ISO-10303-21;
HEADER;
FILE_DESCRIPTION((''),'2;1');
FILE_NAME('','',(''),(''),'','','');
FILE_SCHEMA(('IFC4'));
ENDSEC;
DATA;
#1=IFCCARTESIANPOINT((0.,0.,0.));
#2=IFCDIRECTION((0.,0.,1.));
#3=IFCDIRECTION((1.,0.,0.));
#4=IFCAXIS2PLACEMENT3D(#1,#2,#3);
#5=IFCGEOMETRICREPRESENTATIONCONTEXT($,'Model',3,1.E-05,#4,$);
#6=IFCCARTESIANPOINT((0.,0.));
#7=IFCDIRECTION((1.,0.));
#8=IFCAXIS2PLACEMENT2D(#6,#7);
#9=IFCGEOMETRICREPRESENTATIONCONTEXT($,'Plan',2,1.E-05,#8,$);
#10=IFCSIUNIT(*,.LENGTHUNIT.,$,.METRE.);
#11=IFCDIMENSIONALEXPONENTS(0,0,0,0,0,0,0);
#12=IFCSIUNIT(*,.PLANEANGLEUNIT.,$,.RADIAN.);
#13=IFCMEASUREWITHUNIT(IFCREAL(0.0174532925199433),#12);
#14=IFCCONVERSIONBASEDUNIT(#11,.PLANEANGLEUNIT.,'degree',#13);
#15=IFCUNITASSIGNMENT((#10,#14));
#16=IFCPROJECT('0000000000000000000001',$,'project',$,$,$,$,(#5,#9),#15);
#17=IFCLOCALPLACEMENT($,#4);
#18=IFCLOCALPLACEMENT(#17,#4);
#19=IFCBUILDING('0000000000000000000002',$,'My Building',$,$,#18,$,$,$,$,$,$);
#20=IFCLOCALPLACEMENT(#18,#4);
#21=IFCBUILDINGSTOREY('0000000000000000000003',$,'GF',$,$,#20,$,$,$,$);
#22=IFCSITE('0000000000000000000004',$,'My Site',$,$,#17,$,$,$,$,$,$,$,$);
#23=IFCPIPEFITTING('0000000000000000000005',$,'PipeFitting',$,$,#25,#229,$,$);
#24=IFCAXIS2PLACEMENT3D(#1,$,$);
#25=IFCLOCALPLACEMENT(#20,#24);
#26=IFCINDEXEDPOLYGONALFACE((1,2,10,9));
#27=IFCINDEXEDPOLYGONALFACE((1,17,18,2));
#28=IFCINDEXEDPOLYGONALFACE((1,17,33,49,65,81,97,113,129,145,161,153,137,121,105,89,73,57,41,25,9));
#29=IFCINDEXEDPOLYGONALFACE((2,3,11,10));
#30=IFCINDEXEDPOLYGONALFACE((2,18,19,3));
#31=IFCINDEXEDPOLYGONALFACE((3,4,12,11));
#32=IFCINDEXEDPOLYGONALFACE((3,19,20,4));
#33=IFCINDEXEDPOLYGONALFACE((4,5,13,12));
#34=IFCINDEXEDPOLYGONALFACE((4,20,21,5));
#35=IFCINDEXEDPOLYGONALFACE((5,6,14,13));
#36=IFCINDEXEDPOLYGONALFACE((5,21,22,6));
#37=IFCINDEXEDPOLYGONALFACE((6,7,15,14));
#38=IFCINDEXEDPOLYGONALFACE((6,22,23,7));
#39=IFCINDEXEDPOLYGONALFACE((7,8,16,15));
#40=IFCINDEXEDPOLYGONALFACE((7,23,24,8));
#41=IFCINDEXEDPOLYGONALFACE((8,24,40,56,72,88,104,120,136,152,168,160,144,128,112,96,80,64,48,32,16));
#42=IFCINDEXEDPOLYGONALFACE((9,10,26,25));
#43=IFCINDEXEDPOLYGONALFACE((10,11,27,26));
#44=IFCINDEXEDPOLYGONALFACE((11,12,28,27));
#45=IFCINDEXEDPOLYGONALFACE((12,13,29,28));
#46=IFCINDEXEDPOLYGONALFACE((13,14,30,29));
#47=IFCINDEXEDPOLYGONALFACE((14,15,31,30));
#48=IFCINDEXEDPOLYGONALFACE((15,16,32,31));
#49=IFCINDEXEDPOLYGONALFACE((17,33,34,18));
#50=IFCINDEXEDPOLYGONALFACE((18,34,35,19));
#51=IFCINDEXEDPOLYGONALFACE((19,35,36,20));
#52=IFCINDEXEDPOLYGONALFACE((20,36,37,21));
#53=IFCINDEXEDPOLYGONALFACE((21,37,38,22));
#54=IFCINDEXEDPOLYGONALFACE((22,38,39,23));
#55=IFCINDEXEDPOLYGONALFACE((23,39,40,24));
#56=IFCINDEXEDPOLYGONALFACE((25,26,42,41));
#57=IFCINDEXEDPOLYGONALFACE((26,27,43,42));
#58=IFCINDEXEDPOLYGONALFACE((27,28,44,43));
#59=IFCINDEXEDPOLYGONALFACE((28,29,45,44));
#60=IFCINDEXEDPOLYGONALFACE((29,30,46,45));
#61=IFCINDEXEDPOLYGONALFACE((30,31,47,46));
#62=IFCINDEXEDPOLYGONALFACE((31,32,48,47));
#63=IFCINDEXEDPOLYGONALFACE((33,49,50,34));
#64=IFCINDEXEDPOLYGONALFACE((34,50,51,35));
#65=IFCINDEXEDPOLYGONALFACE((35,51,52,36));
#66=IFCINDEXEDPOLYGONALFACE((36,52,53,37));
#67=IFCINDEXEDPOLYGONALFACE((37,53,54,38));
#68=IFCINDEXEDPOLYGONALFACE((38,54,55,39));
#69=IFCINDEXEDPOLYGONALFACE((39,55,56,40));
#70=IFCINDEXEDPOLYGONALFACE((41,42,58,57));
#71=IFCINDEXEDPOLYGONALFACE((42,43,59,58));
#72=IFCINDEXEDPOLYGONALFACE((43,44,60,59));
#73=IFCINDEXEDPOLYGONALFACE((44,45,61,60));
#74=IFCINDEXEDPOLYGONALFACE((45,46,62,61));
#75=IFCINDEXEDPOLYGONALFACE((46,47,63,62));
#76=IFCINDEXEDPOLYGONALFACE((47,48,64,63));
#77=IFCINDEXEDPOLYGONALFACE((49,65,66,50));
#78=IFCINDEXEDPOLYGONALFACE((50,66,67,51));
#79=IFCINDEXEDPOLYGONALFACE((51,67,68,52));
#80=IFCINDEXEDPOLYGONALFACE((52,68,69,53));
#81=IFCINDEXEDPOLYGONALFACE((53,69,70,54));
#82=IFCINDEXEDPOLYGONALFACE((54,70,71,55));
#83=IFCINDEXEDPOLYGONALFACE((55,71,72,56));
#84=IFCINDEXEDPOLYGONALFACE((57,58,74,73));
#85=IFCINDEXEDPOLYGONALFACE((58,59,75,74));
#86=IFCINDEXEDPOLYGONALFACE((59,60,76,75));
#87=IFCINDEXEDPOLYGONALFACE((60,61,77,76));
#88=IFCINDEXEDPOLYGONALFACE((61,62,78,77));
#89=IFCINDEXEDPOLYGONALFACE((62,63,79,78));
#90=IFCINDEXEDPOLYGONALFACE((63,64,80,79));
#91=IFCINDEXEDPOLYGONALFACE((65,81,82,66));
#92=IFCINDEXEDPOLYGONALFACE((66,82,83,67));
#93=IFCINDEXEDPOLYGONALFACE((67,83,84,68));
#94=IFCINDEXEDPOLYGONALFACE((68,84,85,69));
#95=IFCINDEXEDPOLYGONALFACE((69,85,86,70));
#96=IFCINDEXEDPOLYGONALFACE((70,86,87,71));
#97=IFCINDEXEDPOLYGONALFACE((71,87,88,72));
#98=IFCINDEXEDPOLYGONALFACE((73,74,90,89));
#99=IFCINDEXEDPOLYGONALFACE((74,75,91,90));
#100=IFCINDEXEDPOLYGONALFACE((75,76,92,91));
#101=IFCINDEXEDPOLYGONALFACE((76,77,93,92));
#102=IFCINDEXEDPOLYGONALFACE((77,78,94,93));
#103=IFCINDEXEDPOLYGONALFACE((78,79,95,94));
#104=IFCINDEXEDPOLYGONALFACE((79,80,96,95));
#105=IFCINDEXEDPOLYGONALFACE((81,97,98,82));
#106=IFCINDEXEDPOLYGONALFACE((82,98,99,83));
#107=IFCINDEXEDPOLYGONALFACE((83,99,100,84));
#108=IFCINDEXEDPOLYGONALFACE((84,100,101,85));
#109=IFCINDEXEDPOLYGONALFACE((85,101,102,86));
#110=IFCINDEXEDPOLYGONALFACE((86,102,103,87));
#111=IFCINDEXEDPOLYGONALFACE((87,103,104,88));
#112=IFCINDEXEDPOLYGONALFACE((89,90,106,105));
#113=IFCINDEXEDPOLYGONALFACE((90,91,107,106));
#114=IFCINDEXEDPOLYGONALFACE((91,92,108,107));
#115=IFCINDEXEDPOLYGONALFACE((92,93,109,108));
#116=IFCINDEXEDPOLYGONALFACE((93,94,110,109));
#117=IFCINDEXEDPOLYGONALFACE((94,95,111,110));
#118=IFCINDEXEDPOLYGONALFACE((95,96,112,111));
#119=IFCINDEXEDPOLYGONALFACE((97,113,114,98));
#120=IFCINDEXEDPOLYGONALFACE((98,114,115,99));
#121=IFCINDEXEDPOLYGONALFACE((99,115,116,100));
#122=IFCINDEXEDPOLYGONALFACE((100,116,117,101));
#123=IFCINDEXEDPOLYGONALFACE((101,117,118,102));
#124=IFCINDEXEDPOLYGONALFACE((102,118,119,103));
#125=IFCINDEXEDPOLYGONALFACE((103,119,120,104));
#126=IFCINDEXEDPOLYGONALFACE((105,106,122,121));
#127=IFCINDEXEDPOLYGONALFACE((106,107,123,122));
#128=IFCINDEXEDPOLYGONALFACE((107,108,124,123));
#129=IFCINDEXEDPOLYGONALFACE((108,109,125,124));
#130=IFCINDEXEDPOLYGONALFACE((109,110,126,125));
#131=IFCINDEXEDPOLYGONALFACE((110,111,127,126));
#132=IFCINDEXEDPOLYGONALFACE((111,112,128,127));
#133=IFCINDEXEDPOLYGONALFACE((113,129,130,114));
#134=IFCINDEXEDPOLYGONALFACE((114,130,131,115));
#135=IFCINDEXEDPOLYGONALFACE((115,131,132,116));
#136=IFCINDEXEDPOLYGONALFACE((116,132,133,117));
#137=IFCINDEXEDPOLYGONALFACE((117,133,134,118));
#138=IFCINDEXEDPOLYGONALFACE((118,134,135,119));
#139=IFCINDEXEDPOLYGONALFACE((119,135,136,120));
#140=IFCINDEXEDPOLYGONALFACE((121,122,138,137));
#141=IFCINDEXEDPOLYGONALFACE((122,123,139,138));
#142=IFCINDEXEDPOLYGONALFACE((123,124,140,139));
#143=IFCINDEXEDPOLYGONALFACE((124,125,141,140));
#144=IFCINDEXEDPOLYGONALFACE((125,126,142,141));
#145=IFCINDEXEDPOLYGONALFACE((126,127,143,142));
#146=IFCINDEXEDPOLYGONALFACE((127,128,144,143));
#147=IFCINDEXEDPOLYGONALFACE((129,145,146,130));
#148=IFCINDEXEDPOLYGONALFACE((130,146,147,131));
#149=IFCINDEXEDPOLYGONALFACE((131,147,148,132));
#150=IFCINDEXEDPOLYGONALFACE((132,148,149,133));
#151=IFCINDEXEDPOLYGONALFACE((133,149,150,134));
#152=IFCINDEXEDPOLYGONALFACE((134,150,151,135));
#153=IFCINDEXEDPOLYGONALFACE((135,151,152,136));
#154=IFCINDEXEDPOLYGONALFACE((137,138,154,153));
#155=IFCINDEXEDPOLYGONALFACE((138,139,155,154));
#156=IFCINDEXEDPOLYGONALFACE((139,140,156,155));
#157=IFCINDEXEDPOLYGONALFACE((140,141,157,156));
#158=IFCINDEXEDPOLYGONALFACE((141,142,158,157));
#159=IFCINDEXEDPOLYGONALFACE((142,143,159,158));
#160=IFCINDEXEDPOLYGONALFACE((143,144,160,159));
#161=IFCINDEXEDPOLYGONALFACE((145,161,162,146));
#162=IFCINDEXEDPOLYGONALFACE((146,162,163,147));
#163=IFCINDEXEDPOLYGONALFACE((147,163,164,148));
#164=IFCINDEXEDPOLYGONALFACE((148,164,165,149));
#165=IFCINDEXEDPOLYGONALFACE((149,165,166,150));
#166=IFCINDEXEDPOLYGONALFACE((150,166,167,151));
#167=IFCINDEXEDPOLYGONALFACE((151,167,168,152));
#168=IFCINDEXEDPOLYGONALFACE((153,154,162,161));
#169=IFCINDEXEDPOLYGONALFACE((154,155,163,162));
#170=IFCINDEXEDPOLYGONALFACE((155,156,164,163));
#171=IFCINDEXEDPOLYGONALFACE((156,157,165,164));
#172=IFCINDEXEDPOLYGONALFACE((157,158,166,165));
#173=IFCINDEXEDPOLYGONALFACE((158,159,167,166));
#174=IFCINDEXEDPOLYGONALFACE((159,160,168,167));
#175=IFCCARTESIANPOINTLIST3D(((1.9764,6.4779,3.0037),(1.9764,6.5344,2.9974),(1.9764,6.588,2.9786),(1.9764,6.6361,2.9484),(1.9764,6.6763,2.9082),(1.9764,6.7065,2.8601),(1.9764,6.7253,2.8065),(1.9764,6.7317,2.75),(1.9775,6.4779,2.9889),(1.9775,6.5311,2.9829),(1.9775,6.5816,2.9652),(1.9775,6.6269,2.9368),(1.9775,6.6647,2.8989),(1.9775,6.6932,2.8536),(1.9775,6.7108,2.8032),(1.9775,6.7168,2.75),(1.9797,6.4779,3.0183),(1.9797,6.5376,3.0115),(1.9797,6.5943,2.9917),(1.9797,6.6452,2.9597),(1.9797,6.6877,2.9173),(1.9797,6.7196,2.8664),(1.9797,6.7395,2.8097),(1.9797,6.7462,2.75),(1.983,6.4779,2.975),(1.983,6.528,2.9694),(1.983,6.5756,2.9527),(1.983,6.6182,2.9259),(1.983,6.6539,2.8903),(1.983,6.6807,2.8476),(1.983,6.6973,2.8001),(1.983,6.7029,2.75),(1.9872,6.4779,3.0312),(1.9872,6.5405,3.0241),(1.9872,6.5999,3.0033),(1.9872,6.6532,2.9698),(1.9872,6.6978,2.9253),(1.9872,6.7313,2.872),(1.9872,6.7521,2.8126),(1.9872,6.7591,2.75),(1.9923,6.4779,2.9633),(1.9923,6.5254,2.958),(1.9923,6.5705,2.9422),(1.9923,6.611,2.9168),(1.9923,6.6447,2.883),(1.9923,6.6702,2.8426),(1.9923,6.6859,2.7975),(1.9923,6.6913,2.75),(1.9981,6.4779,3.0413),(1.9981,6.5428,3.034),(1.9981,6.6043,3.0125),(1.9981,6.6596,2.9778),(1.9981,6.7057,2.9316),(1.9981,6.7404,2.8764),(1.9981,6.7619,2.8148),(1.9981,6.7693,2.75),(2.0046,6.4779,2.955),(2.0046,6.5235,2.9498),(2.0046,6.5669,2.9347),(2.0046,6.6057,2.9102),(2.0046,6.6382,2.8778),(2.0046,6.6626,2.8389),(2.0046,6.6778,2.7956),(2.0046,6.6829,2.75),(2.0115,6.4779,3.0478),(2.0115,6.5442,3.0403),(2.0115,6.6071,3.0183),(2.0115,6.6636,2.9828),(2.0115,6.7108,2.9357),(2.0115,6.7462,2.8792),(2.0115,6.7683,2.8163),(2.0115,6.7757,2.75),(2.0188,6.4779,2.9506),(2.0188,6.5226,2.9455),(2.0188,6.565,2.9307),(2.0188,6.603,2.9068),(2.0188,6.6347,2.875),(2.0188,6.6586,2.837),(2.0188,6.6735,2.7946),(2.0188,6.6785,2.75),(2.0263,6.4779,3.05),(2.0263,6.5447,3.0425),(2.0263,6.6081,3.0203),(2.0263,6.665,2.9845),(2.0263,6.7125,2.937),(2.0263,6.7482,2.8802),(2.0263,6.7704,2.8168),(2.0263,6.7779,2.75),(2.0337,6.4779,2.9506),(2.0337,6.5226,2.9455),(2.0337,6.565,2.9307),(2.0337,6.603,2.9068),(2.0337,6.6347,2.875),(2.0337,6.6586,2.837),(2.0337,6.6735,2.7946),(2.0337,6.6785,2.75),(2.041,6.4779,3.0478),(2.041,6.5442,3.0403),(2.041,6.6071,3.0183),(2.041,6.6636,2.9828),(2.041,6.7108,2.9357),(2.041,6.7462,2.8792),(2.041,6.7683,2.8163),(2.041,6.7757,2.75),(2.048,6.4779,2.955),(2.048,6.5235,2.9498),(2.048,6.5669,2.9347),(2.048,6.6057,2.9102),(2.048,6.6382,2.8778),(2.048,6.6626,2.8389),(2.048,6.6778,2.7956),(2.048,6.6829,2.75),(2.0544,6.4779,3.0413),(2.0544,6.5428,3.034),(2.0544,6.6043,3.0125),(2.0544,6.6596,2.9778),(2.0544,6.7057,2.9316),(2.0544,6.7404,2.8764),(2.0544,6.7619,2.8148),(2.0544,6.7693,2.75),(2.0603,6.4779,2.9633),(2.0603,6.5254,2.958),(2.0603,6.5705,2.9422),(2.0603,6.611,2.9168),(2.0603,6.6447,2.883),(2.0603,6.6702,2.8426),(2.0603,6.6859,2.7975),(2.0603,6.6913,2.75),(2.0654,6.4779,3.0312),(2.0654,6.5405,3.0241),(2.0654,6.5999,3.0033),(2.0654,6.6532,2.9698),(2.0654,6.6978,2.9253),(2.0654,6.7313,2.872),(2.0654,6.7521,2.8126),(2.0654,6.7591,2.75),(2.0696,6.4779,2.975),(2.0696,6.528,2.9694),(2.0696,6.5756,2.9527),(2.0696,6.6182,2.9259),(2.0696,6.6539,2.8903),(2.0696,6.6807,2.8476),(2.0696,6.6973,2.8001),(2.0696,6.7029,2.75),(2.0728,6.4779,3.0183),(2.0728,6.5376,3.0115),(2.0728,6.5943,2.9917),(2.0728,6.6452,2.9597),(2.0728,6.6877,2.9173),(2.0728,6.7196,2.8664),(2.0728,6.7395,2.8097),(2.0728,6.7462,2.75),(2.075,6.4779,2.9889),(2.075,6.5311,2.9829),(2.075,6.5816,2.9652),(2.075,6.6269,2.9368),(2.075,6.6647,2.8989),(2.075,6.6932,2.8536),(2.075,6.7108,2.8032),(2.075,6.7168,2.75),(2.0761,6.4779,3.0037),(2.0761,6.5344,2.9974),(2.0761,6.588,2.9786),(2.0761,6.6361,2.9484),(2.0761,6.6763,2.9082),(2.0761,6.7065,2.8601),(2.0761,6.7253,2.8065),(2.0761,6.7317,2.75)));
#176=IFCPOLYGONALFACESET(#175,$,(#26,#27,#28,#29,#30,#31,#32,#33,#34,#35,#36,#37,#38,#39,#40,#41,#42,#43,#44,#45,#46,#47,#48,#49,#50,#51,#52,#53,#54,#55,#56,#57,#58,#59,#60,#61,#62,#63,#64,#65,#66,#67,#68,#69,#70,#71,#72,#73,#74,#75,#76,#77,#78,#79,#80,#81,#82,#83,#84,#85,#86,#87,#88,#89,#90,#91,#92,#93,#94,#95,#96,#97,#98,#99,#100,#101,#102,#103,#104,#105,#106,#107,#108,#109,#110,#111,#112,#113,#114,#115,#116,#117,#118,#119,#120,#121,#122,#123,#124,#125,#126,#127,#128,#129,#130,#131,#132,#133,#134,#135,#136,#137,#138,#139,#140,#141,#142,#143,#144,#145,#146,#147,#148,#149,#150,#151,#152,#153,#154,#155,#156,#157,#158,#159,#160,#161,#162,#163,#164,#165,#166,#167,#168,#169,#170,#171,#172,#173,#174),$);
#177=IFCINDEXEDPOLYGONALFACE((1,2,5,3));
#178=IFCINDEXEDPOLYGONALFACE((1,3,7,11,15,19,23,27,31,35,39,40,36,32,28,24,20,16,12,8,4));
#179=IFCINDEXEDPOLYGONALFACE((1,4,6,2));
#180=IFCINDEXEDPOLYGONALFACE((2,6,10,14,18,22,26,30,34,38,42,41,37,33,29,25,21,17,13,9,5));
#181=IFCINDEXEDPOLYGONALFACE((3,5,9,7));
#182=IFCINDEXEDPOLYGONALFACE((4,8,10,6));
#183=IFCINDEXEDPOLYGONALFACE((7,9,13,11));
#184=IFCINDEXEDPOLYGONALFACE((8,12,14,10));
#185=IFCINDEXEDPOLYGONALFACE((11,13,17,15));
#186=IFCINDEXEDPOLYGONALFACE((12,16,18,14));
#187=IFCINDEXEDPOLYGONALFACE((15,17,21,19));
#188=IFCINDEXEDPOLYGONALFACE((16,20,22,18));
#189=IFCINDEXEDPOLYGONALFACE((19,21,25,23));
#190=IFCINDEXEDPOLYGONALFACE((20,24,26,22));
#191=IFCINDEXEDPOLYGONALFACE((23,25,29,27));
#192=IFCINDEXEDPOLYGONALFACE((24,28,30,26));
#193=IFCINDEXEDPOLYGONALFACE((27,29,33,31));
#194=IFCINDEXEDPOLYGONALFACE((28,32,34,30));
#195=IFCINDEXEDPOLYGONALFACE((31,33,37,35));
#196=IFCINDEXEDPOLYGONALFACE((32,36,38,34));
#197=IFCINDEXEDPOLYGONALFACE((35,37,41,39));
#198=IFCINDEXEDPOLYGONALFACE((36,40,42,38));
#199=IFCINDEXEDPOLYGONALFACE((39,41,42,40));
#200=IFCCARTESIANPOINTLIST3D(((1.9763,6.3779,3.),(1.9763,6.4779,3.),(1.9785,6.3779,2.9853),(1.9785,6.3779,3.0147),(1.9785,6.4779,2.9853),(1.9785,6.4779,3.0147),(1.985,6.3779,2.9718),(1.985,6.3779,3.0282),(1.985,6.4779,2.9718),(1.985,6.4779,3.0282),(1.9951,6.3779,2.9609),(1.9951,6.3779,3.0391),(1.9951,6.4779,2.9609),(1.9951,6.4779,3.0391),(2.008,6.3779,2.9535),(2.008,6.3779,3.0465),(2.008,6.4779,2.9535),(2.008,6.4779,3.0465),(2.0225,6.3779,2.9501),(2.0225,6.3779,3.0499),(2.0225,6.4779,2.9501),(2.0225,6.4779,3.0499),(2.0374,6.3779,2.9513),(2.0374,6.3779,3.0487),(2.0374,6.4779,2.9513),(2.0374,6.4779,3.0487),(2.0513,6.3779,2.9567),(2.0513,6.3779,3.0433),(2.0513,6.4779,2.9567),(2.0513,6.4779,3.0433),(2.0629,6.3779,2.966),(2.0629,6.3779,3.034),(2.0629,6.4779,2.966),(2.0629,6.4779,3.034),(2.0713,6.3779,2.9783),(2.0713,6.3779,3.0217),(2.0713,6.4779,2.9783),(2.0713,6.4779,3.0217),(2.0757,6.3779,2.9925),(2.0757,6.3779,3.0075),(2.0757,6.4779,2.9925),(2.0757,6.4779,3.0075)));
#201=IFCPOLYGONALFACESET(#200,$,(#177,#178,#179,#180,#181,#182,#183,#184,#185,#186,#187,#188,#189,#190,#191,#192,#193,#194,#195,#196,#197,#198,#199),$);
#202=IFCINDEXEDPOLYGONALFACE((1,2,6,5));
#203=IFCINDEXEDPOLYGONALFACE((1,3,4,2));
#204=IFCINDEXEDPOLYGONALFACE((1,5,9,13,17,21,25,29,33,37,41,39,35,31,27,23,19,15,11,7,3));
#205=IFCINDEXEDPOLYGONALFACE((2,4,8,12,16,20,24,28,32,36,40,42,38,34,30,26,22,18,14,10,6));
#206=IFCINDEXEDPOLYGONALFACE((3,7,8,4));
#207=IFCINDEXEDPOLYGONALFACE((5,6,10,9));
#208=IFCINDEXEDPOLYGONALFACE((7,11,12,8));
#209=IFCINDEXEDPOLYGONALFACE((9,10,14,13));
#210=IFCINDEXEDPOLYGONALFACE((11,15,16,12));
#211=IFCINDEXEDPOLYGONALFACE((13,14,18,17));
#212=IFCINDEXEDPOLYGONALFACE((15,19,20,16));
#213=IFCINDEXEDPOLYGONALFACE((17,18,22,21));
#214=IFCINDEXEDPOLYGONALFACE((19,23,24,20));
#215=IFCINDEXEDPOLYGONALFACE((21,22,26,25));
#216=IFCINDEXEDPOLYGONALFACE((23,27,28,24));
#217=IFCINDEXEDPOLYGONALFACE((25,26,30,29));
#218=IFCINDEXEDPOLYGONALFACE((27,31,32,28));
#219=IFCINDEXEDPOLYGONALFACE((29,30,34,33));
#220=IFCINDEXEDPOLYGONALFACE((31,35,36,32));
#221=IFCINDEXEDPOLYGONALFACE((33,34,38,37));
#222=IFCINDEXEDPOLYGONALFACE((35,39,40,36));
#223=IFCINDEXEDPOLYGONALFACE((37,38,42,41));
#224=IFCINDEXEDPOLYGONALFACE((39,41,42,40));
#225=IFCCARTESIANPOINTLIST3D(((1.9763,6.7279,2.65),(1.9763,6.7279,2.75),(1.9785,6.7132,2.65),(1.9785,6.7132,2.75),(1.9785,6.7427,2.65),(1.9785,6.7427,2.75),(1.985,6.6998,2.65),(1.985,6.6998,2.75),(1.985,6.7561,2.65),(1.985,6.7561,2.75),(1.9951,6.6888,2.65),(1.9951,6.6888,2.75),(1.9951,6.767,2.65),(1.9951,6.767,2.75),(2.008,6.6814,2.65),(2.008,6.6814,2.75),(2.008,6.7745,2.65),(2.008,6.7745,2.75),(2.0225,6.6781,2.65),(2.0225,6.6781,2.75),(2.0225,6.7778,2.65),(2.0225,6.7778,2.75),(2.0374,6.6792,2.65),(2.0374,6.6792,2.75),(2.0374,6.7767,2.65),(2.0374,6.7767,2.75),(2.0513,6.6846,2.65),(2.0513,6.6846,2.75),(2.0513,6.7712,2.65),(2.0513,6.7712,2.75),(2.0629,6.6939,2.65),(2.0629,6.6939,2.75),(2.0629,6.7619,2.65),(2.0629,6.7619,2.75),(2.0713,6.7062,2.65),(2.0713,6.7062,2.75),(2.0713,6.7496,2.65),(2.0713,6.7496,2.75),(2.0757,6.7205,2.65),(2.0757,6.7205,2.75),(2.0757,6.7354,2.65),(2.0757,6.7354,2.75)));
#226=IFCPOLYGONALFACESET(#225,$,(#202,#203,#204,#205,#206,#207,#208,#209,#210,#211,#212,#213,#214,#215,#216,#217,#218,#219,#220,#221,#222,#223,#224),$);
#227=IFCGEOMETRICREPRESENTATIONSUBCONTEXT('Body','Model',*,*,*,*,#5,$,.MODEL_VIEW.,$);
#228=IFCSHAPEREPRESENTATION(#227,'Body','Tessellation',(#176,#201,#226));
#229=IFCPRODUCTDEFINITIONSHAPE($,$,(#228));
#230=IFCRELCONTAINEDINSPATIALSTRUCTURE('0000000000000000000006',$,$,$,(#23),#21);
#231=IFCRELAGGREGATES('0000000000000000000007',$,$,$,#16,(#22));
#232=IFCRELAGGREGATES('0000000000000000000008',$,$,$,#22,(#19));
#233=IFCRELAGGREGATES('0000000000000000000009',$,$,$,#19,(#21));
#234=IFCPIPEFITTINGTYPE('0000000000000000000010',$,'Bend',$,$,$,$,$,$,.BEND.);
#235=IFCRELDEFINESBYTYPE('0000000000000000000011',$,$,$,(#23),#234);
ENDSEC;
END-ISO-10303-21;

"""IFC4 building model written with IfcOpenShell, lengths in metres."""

from ifc_helpers import new_model, entity, si_unit, converted_unit, frame, origin_with_axes, origin_2d_with_axis, place, context, subcontext, project, spatial, circle, extrude, source, transform, mapped, type_object, type_shapes, element, save


model = new_model("IFC4")

# Units and contexts
model_context = context("Model", 3, precision=1e-05, world=origin_with_axes())
plan_context = context("Plan", 2, precision=1e-05, world=origin_2d_with_axis())
body_context_1 = subcontext(model_context, "Body", "Model", "MODEL_VIEW")
ifc_project = project(units=[si_unit("LENGTHUNIT", "METRE"), converted_unit("PLANEANGLEUNIT", "degree", entity("IfcReal", 0.0174532925199433), si_unit("PLANEANGLEUNIT", "RADIAN"), dimensions=[0, 0, 0, 0, 0, 0, 0])], contexts=[model_context, plan_context])

# Site, building, storey
site_placement = place(None, origin_with_axes())
site = spatial("IfcSite", under=ifc_project, at=site_placement, Name="My Site")
building_placement = place(site_placement, origin_with_axes())
building = spatial("IfcBuilding", under=site, at=building_placement, Name="My Building")
storey_placement = place(building_placement, origin_with_axes())
storey = spatial("IfcBuildingStorey", under=building, at=storey_placement, Name="GF")

# Pipe fitting
pipe_fitting_type = type_object("IfcPipeFittingType", Name="Bend", PredefinedType="BEND")
shared_shape_1 = source(origin_with_axes(), body_context_1, "Body", "SolidModel", [
    entity("IfcSweptDiskSolid", entity("IfcIndexedPolyCurve", entity("IfcCartesianPointList3D", [[0.0, 0.0, 0.1], [0.0, -0.0732, 0.2768], [0.0, -0.25, 0.35]]), [entity("IfcArcIndex", [1, 2, 3])]), 0.05),
    extrude(circle(Radius=0.05), origin_with_axes(), (0.0, 0.0, 1.0), 0.1),
    extrude(circle(Radius=0.05), frame((0.0, -0.25, 0.35), z_axis=(0.0, -1.0, 0.0), x_axis=(1.0, 0.0, 0.0)), (0.0, 0.0, 1.0), 0.1),
])
type_shapes(pipe_fitting_type, [shared_shape_1])
for number, where, z_axis, x_axis, name in (
    (1, (2.0263, 6.3779, 3.0), (0.0, 1.0, 0.0), (-1.0, 0.0, 0.0), "PipeFitting"),
):
    element("IfcPipeFitting", number, at=place(storey_placement, frame(where, z_axis=z_axis, x_axis=x_axis)), inside=storey, type_object=pipe_fitting_type, Name=name, context=body_context_1, shape_type="MappedRepresentation", body=[
        mapped(shared_shape_1, transform((0.0, 0.0, 0.0), x_axis=(1.0, 0.0, 0.0), y_axis=(0.0, 1.0, 0.0), z_axis=(0.0, 0.0, 1.0), scale=1.0)),
    ])

save(model, "model.ifc")
